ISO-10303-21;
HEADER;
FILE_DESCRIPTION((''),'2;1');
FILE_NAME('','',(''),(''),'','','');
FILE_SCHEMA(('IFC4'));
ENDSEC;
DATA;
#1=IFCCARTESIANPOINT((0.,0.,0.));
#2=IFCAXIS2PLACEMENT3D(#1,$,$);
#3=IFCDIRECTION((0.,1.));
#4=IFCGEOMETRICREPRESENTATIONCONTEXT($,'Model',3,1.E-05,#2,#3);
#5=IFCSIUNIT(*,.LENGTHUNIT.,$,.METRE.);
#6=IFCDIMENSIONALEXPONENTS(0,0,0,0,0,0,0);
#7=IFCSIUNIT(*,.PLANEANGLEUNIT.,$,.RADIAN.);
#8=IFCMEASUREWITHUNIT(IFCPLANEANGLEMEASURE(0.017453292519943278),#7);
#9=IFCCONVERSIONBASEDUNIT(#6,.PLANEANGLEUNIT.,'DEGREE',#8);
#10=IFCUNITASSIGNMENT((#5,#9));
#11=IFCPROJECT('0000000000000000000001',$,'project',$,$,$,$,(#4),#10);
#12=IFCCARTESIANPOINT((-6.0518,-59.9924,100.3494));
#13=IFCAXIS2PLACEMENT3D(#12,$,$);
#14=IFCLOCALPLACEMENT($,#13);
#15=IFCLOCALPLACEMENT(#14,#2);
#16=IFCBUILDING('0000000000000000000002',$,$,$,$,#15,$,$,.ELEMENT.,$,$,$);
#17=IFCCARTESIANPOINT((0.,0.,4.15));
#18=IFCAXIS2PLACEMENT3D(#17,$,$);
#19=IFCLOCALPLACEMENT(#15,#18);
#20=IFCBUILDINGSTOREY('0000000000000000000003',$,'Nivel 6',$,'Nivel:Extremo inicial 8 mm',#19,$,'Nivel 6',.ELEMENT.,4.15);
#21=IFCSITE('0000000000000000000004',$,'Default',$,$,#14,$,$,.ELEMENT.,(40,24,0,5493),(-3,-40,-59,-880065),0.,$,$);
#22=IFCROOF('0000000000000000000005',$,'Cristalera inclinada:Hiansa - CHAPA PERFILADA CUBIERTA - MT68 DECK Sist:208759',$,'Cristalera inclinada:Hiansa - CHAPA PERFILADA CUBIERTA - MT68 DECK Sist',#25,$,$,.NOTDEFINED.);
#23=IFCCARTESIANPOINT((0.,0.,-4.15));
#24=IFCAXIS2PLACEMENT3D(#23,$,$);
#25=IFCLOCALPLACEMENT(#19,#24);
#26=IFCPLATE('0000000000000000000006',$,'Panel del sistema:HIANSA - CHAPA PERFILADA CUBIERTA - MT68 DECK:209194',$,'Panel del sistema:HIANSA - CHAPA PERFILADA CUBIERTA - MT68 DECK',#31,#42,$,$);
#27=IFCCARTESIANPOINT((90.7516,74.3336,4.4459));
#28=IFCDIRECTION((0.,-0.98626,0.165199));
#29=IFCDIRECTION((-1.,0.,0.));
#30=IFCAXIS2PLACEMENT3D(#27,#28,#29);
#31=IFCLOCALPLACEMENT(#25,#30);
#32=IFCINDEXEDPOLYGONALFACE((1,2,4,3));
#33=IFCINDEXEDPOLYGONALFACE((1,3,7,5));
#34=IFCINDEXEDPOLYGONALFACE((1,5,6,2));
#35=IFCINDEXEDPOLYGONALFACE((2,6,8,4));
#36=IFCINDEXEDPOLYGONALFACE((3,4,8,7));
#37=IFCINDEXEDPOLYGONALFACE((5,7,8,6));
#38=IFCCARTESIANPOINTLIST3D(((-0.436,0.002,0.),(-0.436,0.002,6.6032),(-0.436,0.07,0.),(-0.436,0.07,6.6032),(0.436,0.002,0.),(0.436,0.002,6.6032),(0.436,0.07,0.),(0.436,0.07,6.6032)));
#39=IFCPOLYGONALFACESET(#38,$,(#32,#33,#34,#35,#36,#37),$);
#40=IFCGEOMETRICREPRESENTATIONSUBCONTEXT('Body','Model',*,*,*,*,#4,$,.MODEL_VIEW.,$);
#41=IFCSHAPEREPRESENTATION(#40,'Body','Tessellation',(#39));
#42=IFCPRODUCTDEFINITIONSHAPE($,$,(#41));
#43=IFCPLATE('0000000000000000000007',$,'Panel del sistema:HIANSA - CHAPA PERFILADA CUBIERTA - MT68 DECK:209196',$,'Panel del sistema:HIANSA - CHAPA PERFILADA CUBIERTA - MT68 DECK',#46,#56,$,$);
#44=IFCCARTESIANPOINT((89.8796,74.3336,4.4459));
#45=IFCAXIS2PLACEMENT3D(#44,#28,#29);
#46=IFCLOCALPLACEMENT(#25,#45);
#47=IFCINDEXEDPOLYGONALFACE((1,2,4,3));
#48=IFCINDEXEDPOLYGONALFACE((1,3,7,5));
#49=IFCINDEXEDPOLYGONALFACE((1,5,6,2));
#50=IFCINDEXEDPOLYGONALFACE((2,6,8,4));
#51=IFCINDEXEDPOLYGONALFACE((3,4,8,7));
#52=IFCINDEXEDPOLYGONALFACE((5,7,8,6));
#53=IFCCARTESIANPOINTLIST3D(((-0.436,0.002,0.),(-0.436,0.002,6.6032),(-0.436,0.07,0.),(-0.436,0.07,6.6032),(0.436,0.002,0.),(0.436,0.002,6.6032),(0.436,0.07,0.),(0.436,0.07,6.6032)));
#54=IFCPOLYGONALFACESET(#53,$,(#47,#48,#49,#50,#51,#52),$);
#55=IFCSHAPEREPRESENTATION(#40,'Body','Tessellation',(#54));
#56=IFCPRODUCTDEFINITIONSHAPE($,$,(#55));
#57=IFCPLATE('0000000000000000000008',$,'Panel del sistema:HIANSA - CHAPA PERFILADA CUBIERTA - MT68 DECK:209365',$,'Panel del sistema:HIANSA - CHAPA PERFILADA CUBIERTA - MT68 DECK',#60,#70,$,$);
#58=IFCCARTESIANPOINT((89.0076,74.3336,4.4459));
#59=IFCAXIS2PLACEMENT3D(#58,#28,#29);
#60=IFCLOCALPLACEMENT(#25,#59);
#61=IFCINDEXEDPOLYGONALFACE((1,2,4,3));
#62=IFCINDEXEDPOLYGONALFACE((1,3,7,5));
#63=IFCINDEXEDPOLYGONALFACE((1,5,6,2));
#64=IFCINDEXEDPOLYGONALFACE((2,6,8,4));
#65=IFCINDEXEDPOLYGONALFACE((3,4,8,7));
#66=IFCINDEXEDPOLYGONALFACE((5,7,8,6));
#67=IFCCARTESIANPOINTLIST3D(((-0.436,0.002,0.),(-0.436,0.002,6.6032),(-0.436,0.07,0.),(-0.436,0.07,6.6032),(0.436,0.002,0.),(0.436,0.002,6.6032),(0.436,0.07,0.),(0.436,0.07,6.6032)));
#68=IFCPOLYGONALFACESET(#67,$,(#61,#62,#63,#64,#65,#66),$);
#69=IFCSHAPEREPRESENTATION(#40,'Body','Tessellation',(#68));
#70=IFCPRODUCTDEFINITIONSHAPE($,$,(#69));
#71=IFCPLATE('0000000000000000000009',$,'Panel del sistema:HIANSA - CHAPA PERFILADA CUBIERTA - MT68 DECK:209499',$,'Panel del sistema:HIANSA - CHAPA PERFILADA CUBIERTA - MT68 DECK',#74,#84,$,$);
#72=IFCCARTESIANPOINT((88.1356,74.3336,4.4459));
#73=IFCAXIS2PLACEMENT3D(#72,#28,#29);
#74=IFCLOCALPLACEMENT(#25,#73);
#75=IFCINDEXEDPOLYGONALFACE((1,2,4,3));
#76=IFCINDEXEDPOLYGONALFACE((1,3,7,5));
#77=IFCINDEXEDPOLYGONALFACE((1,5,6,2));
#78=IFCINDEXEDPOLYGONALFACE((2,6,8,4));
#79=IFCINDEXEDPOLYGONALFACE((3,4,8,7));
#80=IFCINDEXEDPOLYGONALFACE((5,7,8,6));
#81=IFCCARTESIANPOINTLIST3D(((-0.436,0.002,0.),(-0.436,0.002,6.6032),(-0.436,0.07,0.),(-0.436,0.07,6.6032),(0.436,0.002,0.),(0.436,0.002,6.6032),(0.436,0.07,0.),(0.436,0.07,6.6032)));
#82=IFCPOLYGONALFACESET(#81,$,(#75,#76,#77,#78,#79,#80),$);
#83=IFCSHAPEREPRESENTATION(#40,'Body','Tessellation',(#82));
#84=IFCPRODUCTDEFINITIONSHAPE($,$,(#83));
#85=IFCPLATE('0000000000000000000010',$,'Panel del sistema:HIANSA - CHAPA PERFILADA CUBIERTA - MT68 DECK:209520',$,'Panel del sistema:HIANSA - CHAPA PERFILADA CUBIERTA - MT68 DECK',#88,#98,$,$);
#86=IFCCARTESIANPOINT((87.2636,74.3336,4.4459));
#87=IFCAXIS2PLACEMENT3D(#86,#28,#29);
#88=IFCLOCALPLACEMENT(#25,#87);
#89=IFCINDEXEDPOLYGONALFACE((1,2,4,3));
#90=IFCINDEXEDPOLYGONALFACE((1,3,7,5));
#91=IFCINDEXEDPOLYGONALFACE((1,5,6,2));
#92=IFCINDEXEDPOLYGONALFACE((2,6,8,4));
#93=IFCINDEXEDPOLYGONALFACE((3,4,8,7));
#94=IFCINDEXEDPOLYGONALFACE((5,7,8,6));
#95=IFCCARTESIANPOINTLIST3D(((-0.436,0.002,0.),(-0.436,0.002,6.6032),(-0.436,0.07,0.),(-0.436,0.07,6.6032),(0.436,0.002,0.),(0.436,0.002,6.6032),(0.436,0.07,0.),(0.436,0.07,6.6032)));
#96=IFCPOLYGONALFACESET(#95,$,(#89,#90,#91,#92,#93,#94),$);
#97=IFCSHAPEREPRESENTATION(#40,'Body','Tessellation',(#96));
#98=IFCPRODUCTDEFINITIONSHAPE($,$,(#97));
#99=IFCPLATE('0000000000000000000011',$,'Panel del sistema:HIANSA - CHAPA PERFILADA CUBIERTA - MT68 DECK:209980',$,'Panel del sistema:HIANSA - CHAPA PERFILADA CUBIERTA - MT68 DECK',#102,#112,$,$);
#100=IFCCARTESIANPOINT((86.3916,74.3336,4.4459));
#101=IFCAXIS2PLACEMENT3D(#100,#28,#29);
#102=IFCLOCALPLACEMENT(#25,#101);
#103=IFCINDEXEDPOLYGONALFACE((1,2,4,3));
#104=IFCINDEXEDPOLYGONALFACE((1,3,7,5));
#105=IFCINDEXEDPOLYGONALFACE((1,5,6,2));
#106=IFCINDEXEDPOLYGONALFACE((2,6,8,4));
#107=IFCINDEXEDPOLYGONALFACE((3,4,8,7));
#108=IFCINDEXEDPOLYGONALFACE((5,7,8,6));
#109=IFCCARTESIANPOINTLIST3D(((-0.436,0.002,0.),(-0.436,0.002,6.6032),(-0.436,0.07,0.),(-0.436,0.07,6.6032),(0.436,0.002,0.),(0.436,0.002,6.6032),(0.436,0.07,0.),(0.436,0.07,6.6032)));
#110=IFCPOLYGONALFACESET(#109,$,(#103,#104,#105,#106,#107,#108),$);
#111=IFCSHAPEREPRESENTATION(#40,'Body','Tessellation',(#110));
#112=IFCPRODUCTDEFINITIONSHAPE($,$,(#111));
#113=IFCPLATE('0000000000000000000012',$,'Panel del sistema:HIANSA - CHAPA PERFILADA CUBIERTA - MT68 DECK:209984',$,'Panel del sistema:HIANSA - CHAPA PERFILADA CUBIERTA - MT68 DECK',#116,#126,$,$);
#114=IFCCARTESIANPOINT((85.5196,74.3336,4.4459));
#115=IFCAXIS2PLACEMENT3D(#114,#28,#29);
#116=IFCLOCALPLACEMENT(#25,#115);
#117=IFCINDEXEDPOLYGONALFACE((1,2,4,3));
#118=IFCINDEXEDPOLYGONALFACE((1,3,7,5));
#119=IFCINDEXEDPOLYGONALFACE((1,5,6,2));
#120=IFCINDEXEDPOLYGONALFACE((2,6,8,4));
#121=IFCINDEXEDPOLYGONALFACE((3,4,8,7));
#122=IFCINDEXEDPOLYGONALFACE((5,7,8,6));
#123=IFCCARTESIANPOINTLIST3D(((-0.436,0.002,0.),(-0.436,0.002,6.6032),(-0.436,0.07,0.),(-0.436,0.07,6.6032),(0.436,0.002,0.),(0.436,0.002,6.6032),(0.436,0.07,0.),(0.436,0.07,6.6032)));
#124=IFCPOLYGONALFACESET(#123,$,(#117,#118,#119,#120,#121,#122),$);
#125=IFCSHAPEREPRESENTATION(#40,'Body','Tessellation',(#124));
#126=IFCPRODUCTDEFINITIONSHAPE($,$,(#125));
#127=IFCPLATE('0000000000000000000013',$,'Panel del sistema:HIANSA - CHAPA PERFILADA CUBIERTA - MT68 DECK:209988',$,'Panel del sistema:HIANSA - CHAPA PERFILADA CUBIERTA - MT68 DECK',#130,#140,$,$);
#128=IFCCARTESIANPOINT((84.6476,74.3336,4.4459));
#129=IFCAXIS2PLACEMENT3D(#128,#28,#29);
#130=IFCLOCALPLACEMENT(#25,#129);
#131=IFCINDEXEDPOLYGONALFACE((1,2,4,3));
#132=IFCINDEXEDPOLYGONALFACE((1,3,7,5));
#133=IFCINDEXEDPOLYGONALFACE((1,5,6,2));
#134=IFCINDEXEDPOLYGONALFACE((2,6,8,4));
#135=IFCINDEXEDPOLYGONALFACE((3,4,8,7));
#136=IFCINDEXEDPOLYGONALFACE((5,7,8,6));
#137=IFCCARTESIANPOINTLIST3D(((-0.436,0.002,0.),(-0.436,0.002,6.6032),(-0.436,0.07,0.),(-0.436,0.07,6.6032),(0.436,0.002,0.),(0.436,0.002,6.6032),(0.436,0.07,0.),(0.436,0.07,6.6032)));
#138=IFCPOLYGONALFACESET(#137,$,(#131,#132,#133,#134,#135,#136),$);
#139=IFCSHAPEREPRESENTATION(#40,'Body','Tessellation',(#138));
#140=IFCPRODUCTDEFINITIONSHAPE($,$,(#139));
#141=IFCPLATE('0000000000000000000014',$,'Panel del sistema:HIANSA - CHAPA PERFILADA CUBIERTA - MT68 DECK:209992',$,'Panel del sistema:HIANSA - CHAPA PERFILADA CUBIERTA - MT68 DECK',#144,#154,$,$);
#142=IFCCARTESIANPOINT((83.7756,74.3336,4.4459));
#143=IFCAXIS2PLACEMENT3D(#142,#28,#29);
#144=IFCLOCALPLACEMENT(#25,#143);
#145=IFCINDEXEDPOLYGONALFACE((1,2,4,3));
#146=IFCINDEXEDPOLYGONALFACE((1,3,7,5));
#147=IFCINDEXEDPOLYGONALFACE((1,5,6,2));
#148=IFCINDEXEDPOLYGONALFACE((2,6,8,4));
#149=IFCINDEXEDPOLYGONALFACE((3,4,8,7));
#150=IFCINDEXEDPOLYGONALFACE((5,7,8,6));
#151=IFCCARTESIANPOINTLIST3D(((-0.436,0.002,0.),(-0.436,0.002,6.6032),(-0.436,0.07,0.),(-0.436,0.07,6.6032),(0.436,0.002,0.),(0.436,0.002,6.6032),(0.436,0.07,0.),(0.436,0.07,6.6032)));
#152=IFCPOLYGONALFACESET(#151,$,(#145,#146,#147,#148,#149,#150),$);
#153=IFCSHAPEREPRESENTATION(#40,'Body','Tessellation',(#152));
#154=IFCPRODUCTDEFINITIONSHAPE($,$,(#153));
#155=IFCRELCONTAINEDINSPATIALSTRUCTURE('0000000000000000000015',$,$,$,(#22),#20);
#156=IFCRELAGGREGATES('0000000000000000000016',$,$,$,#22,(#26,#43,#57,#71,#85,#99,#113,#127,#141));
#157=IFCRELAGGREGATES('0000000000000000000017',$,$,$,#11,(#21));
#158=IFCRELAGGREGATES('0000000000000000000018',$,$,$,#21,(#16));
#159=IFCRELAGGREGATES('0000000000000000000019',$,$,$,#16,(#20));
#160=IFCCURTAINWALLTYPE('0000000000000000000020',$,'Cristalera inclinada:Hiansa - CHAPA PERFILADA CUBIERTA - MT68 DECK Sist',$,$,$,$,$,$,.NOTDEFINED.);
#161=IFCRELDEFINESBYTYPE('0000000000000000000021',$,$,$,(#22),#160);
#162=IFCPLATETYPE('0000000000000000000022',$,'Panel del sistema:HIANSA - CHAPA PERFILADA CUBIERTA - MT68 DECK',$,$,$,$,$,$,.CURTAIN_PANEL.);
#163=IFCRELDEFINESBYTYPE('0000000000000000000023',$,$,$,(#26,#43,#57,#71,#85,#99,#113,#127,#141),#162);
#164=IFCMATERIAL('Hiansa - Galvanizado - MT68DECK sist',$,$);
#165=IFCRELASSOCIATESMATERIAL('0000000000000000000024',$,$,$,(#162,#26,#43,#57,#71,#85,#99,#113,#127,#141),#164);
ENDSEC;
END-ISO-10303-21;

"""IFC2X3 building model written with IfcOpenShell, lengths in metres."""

from ifc_helpers import new_model, entity, si_unit, converted_unit, direction, frame, origin, origin_2d_with_axis, place, context, subcontext, project, spatial, rectangle, extrude, source, transform, mapped, material, type_object, type_shapes, element, aggregate, save


model = new_model("IFC2X3")

# Units and contexts
model_context = context("Model", 3, precision=1e-05, world=origin(), true_north=direction((0.0, 1.0)))
body_context = subcontext(model_context, "Body", "Model", "MODEL_VIEW")
ifc_project = project(units=[si_unit("LENGTHUNIT", "METRE"), converted_unit("PLANEANGLEUNIT", "DEGREE", entity("IfcPlaneAngleMeasure", 0.017453292519943278), si_unit("PLANEANGLEUNIT", "RADIAN"), dimensions=[0, 0, 0, 0, 0, 0, 0])], contexts=[model_context])

# Site, building, storey
site_placement = place(None, frame((-6.0518, -59.9924, 100.3494)))
site = spatial("IfcSite", under=ifc_project, at=site_placement, Name="Default", CompositionType="ELEMENT", RefLatitude=(40, 24, 0, 5493), RefLongitude=(-3, -40, -59, -880065), RefElevation=0.0)
building_placement = place(site_placement, origin())
building = spatial("IfcBuilding", under=site, at=building_placement, CompositionType="ELEMENT")
storey_placement = place(building_placement, frame((0.0, 0.0, 4.15)))
storey = spatial("IfcBuildingStorey", under=building, at=storey_placement, Name="Nivel 6", ObjectType="Nivel:Extremo inicial 8 mm", LongName="Nivel 6", CompositionType="ELEMENT", Elevation=4.15)

# Roof, plates
curtain_wall_type = type_object("IfcCurtainWallType", Name="Cristalera inclinada:Hiansa - CHAPA PERFILADA CUBIERTA - MT68 DECK Sist", PredefinedType="NOTDEFINED")
roof_placement = place(storey_placement, frame((0.0, 0.0, -4.15)))
roof = element("IfcRoof", 1, at=roof_placement, inside=storey, type_object=curtain_wall_type, Name="Cristalera inclinada:Hiansa - CHAPA PERFILADA CUBIERTA - MT68 DECK Sist:208759", ObjectType="Cristalera inclinada:Hiansa - CHAPA PERFILADA CUBIERTA - MT68 DECK Sist", ShapeType="NOTDEFINED")
ifc_material_1 = material(Name="Hiansa - Galvanizado - MT68DECK sist")
plate_type_1 = type_object("IfcPlateType", Name="Panel del sistema:HIANSA - CHAPA PERFILADA CUBIERTA - MT68 DECK", PredefinedType="CURTAIN_PANEL", material=ifc_material_1)
shared_shape_1 = source(origin(), body_context, "Body", "SweptSolid", [
    extrude(rectangle(XDim=0.068, YDim=0.872, at=origin_2d_with_axis()), frame((0.0, 0.036, 0.0), z_axis=(0.0, 0.0, 1.0), x_axis=(0.0, 1.0, 0.0)), (0.0, 0.0, 1.0), 6.6032),
])
type_shapes(plate_type_1, [shared_shape_1])
plate_1_placement = place(roof_placement, frame((90.7516, 74.3336, 4.4459), z_axis=(0.0, -0.98626, 0.165199), x_axis=(-1.0, 0.0, 0.0)))
plate_1 = element("IfcPlate", 2, at=plate_1_placement, type_object=plate_type_1, material=ifc_material_1, Name="Panel del sistema:HIANSA - CHAPA PERFILADA CUBIERTA - MT68 DECK:209194", ObjectType="Panel del sistema:HIANSA - CHAPA PERFILADA CUBIERTA - MT68 DECK", context=body_context, shape_type="MappedRepresentation", body=[
    mapped(shared_shape_1, transform((0.0, 0.0, 0.0), scale=1.0)),
])
plate_2_placement = place(roof_placement, frame((89.8796, 74.3336, 4.4459), z_axis=(0.0, -0.98626, 0.165199), x_axis=(-1.0, 0.0, 0.0)))
plate_2 = element("IfcPlate", 3, at=plate_2_placement, type_object=plate_type_1, material=ifc_material_1, Name="Panel del sistema:HIANSA - CHAPA PERFILADA CUBIERTA - MT68 DECK:209196", ObjectType="Panel del sistema:HIANSA - CHAPA PERFILADA CUBIERTA - MT68 DECK", context=body_context, shape_type="MappedRepresentation", body=[
    mapped(shared_shape_1, transform((0.0, 0.0, 0.0), scale=1.0)),
])
plate_3_placement = place(roof_placement, frame((89.0076, 74.3336, 4.4459), z_axis=(0.0, -0.98626, 0.165199), x_axis=(-1.0, 0.0, 0.0)))
plate_3 = element("IfcPlate", 4, at=plate_3_placement, type_object=plate_type_1, material=ifc_material_1, Name="Panel del sistema:HIANSA - CHAPA PERFILADA CUBIERTA - MT68 DECK:209365", ObjectType="Panel del sistema:HIANSA - CHAPA PERFILADA CUBIERTA - MT68 DECK", context=body_context, shape_type="MappedRepresentation", body=[
    mapped(shared_shape_1, transform((0.0, 0.0, 0.0), scale=1.0)),
])
plate_4_placement = place(roof_placement, frame((88.1356, 74.3336, 4.4459), z_axis=(0.0, -0.98626, 0.165199), x_axis=(-1.0, 0.0, 0.0)))
plate_4 = element("IfcPlate", 5, at=plate_4_placement, type_object=plate_type_1, material=ifc_material_1, Name="Panel del sistema:HIANSA - CHAPA PERFILADA CUBIERTA - MT68 DECK:209499", ObjectType="Panel del sistema:HIANSA - CHAPA PERFILADA CUBIERTA - MT68 DECK", context=body_context, shape_type="MappedRepresentation", body=[
    mapped(shared_shape_1, transform((0.0, 0.0, 0.0), scale=1.0)),
])
plate_5_placement = place(roof_placement, frame((87.2636, 74.3336, 4.4459), z_axis=(0.0, -0.98626, 0.165199), x_axis=(-1.0, 0.0, 0.0)))
plate_5 = element("IfcPlate", 6, at=plate_5_placement, type_object=plate_type_1, material=ifc_material_1, Name="Panel del sistema:HIANSA - CHAPA PERFILADA CUBIERTA - MT68 DECK:209520", ObjectType="Panel del sistema:HIANSA - CHAPA PERFILADA CUBIERTA - MT68 DECK", context=body_context, shape_type="MappedRepresentation", body=[
    mapped(shared_shape_1, transform((0.0, 0.0, 0.0), scale=1.0)),
])
plate_6_placement = place(roof_placement, frame((86.3916, 74.3336, 4.4459), z_axis=(0.0, -0.98626, 0.165199), x_axis=(-1.0, 0.0, 0.0)))
plate_6 = element("IfcPlate", 7, at=plate_6_placement, type_object=plate_type_1, material=ifc_material_1, Name="Panel del sistema:HIANSA - CHAPA PERFILADA CUBIERTA - MT68 DECK:209980", ObjectType="Panel del sistema:HIANSA - CHAPA PERFILADA CUBIERTA - MT68 DECK", context=body_context, shape_type="MappedRepresentation", body=[
    mapped(shared_shape_1, transform((0.0, 0.0, 0.0), scale=1.0)),
])
plate_7_placement = place(roof_placement, frame((85.5196, 74.3336, 4.4459), z_axis=(0.0, -0.98626, 0.165199), x_axis=(-1.0, 0.0, 0.0)))
plate_7 = element("IfcPlate", 8, at=plate_7_placement, type_object=plate_type_1, material=ifc_material_1, Name="Panel del sistema:HIANSA - CHAPA PERFILADA CUBIERTA - MT68 DECK:209984", ObjectType="Panel del sistema:HIANSA - CHAPA PERFILADA CUBIERTA - MT68 DECK", context=body_context, shape_type="MappedRepresentation", body=[
    mapped(shared_shape_1, transform((0.0, 0.0, 0.0), scale=1.0)),
])
plate_8_placement = place(roof_placement, frame((84.6476, 74.3336, 4.4459), z_axis=(0.0, -0.98626, 0.165199), x_axis=(-1.0, 0.0, 0.0)))
plate_8 = element("IfcPlate", 9, at=plate_8_placement, type_object=plate_type_1, material=ifc_material_1, Name="Panel del sistema:HIANSA - CHAPA PERFILADA CUBIERTA - MT68 DECK:209988", ObjectType="Panel del sistema:HIANSA - CHAPA PERFILADA CUBIERTA - MT68 DECK", context=body_context, shape_type="MappedRepresentation", body=[
    mapped(shared_shape_1, transform((0.0, 0.0, 0.0), scale=1.0)),
])
plate_9_placement = place(roof_placement, frame((83.7756, 74.3336, 4.4459), z_axis=(0.0, -0.98626, 0.165199), x_axis=(-1.0, 0.0, 0.0)))
plate_9 = element("IfcPlate", 10, at=plate_9_placement, type_object=plate_type_1, material=ifc_material_1, Name="Panel del sistema:HIANSA - CHAPA PERFILADA CUBIERTA - MT68 DECK:209992", ObjectType="Panel del sistema:HIANSA - CHAPA PERFILADA CUBIERTA - MT68 DECK", context=body_context, shape_type="MappedRepresentation", body=[
    mapped(shared_shape_1, transform((0.0, 0.0, 0.0), scale=1.0)),
])
aggregate(roof, [plate_1, plate_2, plate_3, plate_4, plate_5, plate_6, plate_7, plate_8, plate_9])

save(model, "model.ifc")
